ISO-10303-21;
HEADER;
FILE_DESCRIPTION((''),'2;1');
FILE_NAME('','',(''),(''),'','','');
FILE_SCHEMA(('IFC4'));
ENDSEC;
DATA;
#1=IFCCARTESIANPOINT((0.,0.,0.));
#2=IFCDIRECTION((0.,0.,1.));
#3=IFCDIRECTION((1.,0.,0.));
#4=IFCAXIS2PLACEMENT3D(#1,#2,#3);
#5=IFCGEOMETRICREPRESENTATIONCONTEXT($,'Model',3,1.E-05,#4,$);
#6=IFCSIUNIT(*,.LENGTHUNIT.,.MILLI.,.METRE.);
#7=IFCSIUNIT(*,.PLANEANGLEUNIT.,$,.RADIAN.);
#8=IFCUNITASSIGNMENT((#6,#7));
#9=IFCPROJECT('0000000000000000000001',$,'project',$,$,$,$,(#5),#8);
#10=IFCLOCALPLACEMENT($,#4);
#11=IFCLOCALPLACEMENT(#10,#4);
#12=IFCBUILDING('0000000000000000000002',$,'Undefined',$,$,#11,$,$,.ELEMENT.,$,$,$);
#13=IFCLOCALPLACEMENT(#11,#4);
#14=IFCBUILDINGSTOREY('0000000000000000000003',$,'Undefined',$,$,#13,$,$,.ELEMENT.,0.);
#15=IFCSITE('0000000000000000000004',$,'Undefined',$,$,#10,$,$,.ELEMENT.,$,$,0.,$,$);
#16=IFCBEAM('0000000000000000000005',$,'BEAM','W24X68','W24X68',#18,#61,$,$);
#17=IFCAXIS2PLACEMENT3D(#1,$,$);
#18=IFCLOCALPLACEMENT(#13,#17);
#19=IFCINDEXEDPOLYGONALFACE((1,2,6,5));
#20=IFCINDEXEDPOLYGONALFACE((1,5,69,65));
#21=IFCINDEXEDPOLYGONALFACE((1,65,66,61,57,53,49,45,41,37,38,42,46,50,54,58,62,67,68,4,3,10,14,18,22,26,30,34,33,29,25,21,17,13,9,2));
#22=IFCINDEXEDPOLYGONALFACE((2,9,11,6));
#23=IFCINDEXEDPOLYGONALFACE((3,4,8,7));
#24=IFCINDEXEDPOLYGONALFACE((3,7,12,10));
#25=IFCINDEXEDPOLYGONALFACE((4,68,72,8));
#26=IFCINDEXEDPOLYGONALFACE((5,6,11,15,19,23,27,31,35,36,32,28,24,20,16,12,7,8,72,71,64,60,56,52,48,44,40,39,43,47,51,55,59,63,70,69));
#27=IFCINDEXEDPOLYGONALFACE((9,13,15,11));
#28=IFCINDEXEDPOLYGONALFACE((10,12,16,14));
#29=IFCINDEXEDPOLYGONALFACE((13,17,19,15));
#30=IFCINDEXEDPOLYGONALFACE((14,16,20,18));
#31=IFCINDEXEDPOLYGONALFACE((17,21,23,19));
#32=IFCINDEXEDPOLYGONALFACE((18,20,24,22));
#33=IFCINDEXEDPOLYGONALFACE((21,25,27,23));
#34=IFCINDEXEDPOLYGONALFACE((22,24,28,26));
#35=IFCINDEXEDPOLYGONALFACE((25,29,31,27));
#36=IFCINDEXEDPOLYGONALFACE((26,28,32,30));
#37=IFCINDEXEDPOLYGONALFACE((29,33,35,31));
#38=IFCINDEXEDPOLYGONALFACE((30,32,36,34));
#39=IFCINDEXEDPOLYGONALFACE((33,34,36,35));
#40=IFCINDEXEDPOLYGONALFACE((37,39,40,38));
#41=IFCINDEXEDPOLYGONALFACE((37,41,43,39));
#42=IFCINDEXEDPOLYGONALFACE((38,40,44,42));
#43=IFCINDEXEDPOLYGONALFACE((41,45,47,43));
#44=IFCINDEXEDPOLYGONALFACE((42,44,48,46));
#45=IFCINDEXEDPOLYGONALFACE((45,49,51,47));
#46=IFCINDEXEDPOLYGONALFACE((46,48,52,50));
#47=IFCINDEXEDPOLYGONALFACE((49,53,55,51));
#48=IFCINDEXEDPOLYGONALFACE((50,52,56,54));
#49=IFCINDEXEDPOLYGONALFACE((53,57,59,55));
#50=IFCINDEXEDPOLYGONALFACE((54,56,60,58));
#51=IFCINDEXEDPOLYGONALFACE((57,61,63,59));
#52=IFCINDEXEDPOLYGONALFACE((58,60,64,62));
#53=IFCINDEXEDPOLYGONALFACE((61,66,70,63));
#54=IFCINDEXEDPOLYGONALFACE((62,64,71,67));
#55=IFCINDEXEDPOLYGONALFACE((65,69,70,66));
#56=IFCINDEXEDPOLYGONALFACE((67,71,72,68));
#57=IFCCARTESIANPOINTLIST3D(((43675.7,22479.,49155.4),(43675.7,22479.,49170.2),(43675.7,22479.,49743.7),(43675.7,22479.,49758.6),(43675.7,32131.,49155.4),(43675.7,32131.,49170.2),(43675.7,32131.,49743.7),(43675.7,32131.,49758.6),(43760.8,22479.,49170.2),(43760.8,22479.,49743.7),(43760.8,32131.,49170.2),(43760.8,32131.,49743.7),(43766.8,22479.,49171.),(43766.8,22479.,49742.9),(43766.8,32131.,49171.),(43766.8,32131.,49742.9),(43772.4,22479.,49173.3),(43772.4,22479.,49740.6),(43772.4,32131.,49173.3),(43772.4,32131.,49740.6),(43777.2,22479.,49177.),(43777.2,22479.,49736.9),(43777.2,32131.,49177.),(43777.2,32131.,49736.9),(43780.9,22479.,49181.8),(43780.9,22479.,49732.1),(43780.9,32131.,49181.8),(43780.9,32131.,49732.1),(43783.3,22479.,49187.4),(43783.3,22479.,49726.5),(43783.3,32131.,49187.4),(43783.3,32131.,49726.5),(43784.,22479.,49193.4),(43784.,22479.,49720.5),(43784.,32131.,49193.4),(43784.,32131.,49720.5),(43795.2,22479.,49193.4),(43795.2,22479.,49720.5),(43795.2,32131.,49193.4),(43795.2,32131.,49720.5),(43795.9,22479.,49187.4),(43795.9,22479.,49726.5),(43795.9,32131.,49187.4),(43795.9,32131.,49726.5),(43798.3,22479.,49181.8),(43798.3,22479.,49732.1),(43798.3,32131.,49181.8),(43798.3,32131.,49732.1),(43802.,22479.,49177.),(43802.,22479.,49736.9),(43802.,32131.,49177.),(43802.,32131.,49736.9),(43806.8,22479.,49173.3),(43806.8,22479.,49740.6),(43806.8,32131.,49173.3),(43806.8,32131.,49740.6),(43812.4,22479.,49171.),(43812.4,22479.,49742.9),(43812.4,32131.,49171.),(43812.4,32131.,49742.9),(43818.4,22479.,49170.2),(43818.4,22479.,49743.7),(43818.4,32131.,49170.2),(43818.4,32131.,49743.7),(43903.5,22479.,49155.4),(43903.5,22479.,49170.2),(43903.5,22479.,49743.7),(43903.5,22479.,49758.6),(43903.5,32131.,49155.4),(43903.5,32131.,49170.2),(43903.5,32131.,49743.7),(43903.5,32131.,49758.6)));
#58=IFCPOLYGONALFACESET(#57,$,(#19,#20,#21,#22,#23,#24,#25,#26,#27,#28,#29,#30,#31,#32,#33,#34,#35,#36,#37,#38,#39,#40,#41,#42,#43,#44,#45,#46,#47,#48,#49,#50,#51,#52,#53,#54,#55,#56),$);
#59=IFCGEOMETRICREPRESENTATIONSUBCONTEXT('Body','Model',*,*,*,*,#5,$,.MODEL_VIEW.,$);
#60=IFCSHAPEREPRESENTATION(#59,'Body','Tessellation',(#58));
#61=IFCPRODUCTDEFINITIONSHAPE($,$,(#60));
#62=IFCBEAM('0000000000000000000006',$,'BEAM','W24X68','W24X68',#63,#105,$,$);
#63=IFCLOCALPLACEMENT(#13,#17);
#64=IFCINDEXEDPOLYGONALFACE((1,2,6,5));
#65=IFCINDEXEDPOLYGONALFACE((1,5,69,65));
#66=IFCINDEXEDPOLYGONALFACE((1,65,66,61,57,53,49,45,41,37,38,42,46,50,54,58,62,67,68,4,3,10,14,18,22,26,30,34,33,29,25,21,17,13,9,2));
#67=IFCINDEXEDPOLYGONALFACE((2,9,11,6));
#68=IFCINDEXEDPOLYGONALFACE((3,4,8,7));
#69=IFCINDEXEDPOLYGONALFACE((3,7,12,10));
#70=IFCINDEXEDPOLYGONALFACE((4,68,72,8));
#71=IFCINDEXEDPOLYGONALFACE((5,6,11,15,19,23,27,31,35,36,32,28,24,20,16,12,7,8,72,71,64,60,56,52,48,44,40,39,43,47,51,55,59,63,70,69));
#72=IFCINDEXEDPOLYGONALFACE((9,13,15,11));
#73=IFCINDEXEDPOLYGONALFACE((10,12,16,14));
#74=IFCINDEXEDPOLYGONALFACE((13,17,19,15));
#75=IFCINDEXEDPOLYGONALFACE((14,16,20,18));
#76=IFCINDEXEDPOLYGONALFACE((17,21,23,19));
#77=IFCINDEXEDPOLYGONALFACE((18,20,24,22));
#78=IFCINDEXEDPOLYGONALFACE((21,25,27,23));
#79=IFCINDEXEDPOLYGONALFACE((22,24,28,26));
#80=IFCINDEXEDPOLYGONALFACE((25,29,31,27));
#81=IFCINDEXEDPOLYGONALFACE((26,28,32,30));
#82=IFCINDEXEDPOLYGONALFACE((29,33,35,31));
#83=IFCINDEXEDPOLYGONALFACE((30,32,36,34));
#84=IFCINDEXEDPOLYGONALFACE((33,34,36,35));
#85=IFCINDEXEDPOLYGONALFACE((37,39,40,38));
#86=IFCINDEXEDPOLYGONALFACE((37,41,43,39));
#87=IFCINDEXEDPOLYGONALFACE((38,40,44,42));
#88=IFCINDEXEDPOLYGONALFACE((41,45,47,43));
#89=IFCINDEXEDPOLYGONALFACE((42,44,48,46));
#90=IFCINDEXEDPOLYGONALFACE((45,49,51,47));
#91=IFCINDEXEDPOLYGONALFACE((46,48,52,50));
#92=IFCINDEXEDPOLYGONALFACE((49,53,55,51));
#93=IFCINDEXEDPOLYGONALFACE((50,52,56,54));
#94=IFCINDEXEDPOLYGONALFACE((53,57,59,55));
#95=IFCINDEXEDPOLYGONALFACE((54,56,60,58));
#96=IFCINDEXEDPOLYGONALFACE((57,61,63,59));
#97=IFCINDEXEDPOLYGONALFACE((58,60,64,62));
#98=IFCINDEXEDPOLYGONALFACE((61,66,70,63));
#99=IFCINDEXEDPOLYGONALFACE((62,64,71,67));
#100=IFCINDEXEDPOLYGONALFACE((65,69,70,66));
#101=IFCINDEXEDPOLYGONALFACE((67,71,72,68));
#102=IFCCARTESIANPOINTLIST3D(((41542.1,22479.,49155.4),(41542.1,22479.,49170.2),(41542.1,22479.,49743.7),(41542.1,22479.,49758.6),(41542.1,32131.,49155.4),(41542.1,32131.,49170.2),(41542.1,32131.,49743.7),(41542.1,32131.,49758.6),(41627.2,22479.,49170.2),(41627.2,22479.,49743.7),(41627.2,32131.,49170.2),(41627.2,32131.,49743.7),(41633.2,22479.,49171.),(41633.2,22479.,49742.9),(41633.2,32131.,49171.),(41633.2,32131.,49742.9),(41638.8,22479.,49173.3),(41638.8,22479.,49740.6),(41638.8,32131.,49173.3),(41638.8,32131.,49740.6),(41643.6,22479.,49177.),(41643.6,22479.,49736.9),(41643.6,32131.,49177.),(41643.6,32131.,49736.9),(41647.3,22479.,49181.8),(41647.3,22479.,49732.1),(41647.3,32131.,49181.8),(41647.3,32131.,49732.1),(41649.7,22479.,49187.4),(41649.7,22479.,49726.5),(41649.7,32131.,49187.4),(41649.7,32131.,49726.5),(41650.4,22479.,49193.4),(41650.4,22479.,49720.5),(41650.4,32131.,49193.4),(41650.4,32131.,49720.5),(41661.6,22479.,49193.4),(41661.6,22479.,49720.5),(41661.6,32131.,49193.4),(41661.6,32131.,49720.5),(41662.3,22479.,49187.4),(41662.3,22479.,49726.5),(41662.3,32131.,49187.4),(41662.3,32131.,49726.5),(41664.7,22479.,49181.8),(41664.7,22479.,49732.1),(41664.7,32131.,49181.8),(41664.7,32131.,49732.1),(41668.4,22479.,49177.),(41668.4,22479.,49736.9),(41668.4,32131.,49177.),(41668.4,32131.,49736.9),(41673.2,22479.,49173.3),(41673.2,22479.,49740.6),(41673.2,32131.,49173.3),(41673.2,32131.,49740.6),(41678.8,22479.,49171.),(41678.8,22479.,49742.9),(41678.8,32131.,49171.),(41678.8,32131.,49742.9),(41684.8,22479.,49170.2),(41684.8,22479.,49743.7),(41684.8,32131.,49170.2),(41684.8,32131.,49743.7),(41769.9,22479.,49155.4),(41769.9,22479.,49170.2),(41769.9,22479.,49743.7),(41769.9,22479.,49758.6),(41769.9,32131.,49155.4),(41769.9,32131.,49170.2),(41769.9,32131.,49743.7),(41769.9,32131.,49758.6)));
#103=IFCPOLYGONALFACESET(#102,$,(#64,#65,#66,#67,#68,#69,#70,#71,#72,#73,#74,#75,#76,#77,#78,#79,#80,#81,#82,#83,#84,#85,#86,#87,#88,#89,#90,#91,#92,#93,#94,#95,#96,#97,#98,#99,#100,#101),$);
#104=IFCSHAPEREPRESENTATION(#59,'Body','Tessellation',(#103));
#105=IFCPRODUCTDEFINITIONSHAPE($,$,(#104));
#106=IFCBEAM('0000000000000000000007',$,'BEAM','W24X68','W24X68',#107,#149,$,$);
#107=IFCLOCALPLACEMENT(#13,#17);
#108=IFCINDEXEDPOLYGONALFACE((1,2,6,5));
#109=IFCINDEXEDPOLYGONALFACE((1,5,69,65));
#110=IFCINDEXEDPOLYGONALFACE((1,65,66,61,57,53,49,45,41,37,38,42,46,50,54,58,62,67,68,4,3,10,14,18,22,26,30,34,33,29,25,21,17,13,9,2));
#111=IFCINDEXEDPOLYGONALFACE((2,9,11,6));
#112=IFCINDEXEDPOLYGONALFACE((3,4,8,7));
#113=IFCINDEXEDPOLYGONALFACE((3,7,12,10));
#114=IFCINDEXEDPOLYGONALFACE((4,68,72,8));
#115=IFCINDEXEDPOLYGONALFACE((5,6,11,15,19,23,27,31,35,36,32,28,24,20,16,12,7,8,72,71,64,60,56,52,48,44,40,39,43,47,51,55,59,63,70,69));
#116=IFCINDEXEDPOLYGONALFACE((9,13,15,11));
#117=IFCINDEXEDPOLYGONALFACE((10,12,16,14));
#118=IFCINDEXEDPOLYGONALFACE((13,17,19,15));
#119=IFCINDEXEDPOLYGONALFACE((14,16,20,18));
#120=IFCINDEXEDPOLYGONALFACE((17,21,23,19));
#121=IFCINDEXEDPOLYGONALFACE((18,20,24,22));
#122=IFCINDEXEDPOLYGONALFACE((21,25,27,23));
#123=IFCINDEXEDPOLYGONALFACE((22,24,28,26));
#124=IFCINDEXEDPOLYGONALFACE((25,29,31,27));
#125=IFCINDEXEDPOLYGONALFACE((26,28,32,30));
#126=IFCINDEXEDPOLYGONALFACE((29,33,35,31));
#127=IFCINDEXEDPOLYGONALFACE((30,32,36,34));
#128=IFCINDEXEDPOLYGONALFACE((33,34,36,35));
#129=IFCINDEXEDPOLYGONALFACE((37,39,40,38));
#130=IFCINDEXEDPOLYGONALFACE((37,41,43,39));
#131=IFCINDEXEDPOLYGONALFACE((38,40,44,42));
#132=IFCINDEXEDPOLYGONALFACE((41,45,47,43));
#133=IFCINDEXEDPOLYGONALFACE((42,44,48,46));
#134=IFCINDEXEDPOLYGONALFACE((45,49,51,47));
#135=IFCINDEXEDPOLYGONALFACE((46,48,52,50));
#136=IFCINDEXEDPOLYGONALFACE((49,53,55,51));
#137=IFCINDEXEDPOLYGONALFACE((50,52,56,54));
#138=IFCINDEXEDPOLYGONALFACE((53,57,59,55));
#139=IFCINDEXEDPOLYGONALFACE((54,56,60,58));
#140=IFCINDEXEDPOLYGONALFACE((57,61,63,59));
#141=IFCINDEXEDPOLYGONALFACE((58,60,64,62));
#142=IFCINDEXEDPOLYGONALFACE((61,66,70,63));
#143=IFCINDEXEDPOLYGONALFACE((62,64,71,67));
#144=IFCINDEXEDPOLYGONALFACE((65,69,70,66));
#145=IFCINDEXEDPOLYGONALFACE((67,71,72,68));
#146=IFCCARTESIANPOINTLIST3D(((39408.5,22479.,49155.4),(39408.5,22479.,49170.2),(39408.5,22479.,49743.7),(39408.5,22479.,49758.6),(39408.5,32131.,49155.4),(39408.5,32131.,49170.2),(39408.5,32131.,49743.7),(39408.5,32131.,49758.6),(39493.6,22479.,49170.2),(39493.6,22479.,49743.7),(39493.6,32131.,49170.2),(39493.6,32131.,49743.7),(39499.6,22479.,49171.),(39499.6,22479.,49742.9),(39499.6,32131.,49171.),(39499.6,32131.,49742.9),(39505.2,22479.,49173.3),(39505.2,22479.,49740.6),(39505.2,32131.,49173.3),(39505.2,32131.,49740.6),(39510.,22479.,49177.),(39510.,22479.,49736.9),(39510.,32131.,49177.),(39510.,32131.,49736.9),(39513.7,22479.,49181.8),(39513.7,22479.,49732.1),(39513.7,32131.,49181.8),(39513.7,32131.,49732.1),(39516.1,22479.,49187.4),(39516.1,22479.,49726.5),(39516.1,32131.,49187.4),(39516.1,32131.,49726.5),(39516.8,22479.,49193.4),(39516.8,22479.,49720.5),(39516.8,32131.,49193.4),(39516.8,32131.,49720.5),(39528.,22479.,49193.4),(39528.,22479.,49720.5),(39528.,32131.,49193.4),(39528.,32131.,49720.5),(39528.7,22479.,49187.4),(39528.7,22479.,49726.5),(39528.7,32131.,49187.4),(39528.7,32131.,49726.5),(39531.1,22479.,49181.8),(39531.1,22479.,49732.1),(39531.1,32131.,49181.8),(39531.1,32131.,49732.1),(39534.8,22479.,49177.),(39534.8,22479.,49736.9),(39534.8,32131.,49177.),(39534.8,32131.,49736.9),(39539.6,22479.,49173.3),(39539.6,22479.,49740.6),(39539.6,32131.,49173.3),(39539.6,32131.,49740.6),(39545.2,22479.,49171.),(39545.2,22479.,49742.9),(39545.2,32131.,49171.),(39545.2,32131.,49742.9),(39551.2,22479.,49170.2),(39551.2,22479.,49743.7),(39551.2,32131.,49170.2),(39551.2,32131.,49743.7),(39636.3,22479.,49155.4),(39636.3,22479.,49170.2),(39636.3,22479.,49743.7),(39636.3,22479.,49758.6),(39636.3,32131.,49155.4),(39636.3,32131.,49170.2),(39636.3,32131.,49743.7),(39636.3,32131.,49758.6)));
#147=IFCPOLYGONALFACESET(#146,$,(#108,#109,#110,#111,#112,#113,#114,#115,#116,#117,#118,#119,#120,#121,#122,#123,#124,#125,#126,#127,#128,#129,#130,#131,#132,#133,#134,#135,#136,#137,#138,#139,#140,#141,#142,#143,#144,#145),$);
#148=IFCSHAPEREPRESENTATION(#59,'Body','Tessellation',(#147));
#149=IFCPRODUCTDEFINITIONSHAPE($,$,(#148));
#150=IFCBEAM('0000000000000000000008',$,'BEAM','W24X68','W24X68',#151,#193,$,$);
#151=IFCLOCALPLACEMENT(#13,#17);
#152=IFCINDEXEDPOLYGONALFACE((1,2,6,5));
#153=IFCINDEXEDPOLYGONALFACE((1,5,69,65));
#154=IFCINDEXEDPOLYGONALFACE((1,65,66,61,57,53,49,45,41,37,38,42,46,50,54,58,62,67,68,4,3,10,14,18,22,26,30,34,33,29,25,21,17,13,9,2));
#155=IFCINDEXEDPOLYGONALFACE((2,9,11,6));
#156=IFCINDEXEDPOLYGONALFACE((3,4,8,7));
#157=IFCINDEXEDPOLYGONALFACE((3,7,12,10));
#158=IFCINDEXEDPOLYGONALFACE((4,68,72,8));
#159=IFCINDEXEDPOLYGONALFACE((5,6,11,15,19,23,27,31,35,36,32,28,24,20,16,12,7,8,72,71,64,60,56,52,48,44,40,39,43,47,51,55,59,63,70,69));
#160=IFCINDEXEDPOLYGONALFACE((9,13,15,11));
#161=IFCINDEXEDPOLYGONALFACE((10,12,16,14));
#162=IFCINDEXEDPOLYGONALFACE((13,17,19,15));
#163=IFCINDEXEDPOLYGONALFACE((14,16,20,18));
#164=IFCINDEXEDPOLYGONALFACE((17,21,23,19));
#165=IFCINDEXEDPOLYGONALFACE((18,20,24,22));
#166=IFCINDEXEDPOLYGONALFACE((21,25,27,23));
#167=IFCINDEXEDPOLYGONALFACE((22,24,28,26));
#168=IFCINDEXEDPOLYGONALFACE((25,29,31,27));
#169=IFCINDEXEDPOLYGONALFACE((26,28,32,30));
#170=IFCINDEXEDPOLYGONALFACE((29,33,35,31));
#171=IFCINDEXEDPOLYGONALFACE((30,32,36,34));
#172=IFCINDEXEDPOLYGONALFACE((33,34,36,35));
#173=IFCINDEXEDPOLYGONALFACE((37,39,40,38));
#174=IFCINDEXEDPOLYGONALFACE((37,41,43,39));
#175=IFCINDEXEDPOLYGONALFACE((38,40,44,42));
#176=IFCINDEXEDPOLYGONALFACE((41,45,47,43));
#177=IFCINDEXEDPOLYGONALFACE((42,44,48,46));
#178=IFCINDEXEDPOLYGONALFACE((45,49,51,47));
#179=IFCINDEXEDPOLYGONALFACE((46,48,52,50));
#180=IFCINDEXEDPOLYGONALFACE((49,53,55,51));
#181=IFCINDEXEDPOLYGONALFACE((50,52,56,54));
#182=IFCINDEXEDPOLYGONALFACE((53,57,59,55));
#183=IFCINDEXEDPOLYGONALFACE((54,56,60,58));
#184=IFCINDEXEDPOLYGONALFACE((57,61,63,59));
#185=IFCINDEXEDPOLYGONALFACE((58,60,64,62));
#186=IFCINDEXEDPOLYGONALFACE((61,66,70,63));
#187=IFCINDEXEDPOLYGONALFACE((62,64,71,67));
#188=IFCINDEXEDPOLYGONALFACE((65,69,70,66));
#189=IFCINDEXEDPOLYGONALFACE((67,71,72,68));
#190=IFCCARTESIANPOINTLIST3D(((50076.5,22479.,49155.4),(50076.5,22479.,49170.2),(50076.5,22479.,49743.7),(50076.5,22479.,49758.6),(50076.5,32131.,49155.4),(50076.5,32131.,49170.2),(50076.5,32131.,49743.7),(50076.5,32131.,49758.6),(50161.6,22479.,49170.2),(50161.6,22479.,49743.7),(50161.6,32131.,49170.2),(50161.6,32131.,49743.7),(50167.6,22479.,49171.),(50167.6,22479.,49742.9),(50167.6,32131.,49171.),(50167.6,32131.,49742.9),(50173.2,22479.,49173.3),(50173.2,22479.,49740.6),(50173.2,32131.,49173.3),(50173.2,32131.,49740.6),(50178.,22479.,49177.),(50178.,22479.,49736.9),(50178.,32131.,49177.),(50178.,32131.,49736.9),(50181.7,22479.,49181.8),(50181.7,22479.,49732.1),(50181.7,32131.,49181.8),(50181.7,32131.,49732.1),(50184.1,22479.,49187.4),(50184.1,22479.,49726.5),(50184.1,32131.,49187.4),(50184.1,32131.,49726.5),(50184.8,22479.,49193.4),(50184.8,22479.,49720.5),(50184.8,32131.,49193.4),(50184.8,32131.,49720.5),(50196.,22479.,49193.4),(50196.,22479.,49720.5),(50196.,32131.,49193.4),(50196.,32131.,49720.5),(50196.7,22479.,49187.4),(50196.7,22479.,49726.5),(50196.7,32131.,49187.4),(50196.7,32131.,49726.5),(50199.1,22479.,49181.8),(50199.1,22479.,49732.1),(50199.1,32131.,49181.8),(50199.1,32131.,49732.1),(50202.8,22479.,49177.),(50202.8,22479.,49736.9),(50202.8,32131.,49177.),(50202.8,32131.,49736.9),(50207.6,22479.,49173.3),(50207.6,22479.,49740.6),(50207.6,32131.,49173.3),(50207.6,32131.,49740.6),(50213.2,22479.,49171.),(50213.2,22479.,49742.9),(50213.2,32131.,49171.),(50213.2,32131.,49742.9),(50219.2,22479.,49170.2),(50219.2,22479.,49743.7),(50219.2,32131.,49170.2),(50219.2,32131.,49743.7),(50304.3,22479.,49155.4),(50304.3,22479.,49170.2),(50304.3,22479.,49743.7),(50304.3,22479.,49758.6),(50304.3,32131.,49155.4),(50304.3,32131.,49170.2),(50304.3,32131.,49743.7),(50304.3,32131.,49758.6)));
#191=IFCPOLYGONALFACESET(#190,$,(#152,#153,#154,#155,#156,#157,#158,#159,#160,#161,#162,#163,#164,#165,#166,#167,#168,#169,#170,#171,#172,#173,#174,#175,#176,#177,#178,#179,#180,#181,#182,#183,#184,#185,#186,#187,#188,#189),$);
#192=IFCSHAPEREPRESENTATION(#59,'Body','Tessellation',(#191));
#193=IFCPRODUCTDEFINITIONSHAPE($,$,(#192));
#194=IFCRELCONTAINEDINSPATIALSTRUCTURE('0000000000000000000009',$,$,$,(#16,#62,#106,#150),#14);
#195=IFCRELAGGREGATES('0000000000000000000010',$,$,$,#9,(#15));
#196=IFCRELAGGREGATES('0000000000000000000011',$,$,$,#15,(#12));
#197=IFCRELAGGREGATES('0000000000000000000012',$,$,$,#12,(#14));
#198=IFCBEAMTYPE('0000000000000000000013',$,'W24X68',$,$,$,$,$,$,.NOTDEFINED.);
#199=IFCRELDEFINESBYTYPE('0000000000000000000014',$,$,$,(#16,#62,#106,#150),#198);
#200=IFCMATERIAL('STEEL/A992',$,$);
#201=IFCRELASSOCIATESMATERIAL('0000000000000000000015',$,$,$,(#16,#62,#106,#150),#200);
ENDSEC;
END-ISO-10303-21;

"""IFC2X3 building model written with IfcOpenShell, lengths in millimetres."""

from ifc_helpers import new_model, si_unit, frame, origin_with_axes, origin_2d_with_axis, place, context, subcontext, project, spatial, i_section, extrude, material, type_object, element, save


model = new_model("IFC2X3")

# Units and contexts
model_context = context("Model", 3, precision=1e-05, world=origin_with_axes())
body_context = subcontext(model_context, "Body", "Model", "MODEL_VIEW")
ifc_project = project(units=[si_unit("LENGTHUNIT", "METRE", prefix="MILLI"), si_unit("PLANEANGLEUNIT", "RADIAN")], contexts=[model_context])

# Site, building, storey
site_placement = place(None, origin_with_axes())
site = spatial("IfcSite", under=ifc_project, at=site_placement, Name="Undefined", CompositionType="ELEMENT", RefElevation=0.0)
building_placement = place(site_placement, origin_with_axes())
building = spatial("IfcBuilding", under=site, at=building_placement, Name="Undefined", CompositionType="ELEMENT")
storey_placement = place(building_placement, origin_with_axes())
storey = spatial("IfcBuildingStorey", under=building, at=storey_placement, Name="Undefined", CompositionType="ELEMENT", Elevation=0.0)

# Shared definitions
ifc_material = material(Name="STEEL/A992")

# Beams
beam_type = type_object("IfcBeamType", Name="W24X68", PredefinedType="NOTDEFINED")
for number, where, z_axis, x_axis, name in (
    (1, (43789.6, 22479.0, 49457.0), (0.0, 0.0, 1.0), (0.0, 1.0, 0.0), "BEAM"),
    (2, (41656.0, 22479.0, 49457.0), (0.0, 0.0, 1.0), (0.0, 1.0, 0.0), "BEAM"),
    (3, (39522.4, 22479.0, 49457.0), (0.0, 0.0, 1.0), (0.0, 1.0, 0.0), "BEAM"),
    (4, (50190.4, 22479.0, 49457.0), (0.0, 0.0, 1.0), (0.0, 1.0, 0.0), "BEAM"),
):
    element("IfcBeam", number, at=place(storey_placement, frame(where, z_axis=z_axis, x_axis=x_axis)), inside=storey, type_object=beam_type, material=ifc_material, Name=name, Description="W24X68", ObjectType="W24X68", context=body_context, shape_type="SweptSolid", body=[
        extrude(i_section(OverallWidth=227.8, OverallDepth=603.2, WebThickness=11.1, FlangeThickness=14.9, FilletRadius=23.2, at=origin_2d_with_axis()), frame((9652.0, 0.0, 0.0), z_axis=(-1.0, 0.0, 0.0), x_axis=(0.0, -1.0, 0.0)), (0.0, 0.0, 1.0), 9652.0),
    ])

save(model, "model.ifc")
